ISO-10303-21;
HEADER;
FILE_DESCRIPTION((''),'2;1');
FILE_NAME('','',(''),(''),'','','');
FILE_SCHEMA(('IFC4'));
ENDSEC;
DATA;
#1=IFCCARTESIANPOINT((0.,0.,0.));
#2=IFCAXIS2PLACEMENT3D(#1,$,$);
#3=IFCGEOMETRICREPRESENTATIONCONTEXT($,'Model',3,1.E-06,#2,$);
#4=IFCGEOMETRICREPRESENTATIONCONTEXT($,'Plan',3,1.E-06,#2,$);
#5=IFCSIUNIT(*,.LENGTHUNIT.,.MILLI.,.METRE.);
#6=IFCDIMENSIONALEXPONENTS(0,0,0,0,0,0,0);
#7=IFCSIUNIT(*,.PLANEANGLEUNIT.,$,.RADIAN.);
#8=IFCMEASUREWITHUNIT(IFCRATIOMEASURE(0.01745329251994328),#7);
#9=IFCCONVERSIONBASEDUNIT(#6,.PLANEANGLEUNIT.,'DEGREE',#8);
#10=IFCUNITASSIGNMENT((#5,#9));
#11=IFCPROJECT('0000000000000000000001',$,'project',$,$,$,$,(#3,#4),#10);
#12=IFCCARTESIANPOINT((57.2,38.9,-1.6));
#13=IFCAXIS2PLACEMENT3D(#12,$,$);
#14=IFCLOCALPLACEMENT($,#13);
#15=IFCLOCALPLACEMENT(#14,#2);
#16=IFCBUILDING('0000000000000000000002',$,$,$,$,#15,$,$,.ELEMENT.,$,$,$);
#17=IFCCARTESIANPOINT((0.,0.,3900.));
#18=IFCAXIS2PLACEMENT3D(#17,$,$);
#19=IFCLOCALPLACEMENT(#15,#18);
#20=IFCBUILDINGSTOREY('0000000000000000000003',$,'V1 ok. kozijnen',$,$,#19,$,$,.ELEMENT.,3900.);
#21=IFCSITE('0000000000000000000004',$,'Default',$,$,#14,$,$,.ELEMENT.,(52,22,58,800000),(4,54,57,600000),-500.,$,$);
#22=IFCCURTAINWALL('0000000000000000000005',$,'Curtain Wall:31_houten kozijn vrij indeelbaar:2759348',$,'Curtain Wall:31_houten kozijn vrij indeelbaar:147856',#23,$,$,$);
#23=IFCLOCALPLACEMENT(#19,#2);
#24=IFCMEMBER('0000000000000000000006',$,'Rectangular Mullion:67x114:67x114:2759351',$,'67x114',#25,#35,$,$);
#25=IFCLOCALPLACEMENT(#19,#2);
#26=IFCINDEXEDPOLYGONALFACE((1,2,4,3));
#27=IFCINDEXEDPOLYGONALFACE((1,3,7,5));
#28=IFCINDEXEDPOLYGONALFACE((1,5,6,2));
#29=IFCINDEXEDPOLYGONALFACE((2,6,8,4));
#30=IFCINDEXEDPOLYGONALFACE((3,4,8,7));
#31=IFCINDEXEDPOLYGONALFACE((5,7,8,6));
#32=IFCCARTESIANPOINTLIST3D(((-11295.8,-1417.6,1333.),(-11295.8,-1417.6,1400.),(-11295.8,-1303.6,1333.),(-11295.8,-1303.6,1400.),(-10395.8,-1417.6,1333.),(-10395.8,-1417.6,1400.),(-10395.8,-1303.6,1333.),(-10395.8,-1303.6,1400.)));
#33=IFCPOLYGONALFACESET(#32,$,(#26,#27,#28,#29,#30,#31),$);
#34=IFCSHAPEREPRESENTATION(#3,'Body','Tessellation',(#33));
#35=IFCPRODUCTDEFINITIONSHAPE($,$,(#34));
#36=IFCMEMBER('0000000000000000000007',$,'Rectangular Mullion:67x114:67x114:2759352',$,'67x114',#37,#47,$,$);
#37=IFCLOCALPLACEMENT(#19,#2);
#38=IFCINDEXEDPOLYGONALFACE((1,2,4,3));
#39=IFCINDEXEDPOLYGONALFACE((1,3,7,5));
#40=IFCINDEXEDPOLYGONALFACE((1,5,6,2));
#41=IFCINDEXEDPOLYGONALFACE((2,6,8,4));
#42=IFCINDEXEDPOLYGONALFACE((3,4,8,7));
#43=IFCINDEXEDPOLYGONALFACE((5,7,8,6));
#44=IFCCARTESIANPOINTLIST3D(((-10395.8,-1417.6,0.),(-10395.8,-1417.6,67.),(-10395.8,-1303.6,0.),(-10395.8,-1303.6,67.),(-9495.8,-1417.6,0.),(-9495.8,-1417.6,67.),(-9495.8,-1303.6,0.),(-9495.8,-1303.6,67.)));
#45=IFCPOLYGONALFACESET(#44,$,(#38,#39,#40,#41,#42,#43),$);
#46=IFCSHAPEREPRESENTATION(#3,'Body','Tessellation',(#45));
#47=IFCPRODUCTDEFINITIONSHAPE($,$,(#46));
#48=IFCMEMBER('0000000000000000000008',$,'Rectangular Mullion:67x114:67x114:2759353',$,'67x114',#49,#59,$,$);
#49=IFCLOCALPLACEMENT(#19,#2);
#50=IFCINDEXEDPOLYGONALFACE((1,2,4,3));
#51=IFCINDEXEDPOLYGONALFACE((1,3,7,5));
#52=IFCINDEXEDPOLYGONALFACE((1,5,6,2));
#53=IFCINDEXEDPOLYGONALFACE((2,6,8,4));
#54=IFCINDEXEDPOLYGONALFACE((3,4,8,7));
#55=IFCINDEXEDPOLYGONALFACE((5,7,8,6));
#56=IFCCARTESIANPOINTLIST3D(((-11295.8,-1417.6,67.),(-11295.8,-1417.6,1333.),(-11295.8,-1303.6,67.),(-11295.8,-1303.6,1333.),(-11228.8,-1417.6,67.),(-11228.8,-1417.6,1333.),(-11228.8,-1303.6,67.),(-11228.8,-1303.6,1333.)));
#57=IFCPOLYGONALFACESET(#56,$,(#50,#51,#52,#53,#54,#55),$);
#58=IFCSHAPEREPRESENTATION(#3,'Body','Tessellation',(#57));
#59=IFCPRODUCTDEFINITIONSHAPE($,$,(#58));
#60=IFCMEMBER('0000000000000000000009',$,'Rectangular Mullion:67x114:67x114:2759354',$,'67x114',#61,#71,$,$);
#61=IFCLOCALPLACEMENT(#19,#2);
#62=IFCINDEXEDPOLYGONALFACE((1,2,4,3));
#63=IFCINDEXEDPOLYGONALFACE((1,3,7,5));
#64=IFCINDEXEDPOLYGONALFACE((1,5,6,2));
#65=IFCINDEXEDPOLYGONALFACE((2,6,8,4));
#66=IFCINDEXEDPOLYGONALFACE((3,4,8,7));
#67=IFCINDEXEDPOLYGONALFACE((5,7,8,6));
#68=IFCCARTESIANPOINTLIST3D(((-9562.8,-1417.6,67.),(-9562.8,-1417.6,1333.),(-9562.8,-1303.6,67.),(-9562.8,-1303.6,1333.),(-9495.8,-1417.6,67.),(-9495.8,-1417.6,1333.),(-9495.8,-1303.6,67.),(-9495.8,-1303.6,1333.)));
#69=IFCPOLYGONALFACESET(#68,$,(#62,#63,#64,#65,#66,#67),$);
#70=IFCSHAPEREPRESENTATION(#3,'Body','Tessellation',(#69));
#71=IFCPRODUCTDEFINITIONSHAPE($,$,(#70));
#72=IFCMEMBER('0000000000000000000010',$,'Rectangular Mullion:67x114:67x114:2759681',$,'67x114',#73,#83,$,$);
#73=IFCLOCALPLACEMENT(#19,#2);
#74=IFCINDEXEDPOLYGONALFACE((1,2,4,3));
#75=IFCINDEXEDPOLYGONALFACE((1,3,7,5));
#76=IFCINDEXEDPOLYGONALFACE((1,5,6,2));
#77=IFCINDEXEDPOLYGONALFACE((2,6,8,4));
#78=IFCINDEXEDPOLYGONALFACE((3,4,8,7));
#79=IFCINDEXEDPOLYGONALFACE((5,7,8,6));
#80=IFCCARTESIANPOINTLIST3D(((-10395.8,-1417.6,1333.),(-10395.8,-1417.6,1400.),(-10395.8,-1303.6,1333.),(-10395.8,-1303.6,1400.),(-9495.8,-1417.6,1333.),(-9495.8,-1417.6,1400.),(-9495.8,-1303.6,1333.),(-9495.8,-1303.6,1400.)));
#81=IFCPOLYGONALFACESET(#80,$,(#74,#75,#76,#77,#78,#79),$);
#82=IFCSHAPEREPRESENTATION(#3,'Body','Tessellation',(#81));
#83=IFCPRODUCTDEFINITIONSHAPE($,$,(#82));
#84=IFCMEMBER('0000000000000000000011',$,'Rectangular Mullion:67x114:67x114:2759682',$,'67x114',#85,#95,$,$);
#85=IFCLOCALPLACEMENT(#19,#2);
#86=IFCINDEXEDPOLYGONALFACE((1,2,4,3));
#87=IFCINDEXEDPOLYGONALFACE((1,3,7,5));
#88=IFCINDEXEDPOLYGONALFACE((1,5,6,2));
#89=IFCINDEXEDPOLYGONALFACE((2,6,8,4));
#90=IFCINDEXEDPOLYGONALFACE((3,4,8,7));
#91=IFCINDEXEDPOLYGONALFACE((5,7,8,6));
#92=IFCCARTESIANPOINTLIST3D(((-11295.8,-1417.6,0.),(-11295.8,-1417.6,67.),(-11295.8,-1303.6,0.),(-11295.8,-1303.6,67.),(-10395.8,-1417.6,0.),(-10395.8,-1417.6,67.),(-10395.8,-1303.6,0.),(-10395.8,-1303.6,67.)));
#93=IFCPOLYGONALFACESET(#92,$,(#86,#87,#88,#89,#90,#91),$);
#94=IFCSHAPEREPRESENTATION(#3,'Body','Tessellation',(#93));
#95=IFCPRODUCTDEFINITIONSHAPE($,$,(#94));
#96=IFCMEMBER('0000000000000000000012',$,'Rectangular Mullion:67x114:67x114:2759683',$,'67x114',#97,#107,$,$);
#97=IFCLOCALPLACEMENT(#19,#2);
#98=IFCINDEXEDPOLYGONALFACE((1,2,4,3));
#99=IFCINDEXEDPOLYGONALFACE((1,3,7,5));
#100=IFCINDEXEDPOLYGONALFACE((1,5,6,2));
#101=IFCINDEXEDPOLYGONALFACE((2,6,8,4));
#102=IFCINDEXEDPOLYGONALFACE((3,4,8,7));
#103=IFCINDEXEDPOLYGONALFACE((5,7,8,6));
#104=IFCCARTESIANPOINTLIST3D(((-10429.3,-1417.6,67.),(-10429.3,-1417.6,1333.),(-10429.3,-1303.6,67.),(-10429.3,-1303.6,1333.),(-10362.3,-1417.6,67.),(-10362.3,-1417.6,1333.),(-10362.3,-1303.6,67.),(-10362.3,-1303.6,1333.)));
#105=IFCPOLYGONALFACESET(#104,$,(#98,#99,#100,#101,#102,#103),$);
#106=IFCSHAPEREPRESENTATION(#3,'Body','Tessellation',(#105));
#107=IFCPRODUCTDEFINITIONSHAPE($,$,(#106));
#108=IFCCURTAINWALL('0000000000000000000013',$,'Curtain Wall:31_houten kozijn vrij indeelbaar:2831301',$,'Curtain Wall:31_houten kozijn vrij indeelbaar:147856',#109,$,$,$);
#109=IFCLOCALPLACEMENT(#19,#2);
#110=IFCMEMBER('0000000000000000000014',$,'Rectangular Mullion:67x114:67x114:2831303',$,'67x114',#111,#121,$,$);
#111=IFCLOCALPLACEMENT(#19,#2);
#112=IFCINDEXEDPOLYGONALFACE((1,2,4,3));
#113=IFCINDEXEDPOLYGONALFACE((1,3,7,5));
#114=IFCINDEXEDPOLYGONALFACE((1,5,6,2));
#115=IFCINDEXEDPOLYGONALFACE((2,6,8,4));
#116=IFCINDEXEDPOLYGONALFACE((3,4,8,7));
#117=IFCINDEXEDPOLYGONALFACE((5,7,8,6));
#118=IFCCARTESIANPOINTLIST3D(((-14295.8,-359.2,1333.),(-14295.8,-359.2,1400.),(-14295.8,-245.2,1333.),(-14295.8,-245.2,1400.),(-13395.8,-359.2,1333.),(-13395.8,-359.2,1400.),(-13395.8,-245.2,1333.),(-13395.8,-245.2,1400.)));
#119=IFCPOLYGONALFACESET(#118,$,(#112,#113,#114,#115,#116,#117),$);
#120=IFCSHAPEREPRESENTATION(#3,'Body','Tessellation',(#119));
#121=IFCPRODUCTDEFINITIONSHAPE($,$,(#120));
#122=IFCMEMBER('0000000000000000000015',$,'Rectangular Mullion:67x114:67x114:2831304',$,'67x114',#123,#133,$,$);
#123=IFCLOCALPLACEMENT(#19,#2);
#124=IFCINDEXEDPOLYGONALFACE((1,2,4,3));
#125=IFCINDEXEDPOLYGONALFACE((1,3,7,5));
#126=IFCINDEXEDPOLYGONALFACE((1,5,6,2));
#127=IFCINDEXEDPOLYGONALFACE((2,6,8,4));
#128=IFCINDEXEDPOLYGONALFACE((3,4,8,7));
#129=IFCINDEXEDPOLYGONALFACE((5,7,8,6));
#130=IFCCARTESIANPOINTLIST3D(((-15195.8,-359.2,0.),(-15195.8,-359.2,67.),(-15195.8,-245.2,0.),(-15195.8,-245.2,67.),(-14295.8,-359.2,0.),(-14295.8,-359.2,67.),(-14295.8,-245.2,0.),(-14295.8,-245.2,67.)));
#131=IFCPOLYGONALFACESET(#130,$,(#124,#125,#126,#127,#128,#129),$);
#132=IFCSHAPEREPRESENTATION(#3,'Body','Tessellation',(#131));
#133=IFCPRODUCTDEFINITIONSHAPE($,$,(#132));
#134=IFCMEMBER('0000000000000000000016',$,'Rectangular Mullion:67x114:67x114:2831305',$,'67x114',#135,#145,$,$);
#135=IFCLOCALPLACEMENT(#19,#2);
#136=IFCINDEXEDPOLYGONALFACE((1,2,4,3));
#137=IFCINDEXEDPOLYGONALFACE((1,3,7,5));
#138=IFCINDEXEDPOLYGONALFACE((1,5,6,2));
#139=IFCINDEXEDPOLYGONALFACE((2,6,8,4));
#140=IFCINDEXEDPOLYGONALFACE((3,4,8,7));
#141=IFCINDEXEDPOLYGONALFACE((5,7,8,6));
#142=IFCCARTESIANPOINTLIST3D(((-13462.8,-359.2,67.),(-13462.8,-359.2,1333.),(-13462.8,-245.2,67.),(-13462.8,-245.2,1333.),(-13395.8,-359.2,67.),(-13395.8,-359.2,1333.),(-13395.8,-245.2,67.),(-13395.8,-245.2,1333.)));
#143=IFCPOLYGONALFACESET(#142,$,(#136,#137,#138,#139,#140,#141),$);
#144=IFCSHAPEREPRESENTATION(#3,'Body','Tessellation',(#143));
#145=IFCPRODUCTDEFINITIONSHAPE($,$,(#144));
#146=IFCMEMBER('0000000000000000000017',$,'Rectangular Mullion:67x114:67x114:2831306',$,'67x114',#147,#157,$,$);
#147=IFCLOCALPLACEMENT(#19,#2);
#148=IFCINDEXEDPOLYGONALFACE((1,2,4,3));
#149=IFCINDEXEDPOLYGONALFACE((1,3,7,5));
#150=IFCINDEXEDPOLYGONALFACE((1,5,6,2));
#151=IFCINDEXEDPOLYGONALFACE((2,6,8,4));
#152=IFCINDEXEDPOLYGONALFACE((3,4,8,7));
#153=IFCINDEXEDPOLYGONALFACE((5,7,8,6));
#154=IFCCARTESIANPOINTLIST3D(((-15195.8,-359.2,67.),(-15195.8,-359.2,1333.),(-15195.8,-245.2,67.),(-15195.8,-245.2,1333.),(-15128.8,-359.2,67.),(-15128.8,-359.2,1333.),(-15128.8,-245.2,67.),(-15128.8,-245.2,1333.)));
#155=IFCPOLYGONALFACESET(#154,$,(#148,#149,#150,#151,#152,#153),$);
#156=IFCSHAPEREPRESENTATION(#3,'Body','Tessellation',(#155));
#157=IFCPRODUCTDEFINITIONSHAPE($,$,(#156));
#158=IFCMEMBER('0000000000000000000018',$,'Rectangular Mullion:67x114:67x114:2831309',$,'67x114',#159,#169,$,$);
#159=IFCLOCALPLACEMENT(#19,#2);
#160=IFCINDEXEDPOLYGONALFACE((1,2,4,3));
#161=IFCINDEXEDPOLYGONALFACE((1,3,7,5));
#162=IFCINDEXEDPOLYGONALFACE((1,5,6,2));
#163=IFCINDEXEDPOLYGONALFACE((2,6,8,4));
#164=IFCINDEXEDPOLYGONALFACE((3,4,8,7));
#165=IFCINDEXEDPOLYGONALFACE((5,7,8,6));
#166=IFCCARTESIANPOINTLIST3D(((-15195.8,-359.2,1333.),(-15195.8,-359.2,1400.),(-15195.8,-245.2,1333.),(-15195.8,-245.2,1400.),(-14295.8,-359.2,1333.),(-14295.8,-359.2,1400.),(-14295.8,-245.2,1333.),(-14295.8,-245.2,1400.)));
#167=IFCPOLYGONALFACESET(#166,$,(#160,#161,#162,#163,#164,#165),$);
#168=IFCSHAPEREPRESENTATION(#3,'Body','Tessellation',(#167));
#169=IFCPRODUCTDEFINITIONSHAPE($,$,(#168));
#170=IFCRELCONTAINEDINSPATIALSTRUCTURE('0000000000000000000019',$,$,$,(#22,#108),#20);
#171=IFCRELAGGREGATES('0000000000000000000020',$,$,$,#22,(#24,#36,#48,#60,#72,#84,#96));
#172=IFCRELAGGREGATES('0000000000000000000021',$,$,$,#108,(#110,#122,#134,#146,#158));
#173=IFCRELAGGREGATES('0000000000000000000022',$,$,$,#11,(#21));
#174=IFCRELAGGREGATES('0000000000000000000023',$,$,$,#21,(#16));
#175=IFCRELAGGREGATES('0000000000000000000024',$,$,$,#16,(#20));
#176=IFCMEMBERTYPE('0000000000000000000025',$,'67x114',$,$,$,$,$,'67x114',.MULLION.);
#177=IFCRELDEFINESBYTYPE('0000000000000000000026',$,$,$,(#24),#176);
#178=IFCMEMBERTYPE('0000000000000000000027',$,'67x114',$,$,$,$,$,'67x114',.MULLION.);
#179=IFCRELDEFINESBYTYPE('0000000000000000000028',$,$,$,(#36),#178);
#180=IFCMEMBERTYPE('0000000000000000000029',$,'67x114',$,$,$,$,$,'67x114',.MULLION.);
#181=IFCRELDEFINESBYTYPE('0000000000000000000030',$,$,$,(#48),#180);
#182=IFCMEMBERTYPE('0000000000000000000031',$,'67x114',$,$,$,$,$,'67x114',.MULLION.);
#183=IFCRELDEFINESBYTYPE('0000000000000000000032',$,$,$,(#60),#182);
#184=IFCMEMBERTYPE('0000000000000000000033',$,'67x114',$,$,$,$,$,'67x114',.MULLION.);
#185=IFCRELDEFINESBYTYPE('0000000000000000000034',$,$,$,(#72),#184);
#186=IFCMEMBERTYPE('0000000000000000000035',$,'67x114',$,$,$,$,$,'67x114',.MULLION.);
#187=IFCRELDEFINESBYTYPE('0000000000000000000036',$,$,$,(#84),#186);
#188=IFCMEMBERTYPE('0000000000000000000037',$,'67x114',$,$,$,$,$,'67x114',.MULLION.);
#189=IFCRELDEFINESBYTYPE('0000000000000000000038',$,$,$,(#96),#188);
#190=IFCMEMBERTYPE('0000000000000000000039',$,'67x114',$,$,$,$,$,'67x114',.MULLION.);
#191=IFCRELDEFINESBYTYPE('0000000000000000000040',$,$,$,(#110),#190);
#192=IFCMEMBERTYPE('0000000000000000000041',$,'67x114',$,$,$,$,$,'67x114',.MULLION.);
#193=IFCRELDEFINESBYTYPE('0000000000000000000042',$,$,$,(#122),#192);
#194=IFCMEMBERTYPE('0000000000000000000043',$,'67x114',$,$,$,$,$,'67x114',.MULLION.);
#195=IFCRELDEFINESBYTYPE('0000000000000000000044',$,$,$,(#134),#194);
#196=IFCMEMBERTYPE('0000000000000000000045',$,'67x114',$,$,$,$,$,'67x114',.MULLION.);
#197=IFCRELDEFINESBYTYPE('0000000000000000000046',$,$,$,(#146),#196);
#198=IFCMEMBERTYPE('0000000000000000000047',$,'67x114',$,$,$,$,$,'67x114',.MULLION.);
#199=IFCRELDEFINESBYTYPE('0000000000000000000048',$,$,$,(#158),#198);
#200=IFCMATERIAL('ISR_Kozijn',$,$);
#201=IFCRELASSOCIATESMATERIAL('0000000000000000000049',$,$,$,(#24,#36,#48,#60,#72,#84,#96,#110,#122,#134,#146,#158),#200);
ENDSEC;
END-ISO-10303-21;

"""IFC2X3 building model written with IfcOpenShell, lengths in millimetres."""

from ifc_helpers import new_model, entity, si_unit, converted_unit, frame, origin, origin_2d_with_axis, place, context, project, spatial, rectangle, extrude, source, transform, mapped, material, type_object, type_shapes, element, aggregate, save


model = new_model("IFC2X3")

# Units and contexts
model_context = context("Model", 3, precision=1e-06, world=origin())
plan_context = context("Plan", 3, precision=1e-06, world=origin())
ifc_project = project(units=[si_unit("LENGTHUNIT", "METRE", prefix="MILLI"), converted_unit("PLANEANGLEUNIT", "DEGREE", entity("IfcRatioMeasure", 0.01745329251994328), si_unit("PLANEANGLEUNIT", "RADIAN"), dimensions=[0, 0, 0, 0, 0, 0, 0])], contexts=[model_context, plan_context])

# Site, building, storey
site_placement = place(None, frame((57.2, 38.9, -1.6)))
site = spatial("IfcSite", under=ifc_project, at=site_placement, Name="Default", CompositionType="ELEMENT", RefLatitude=(52, 22, 58, 800000), RefLongitude=(4, 54, 57, 600000), RefElevation=-500.0)
building_placement = place(site_placement, origin())
building = spatial("IfcBuilding", under=site, at=building_placement, CompositionType="ELEMENT")
storey_placement = place(building_placement, frame((0.0, 0.0, 3900.0)))
storey = spatial("IfcBuildingStorey", under=building, at=storey_placement, Name="V1 ok. kozijnen", CompositionType="ELEMENT", Elevation=3900.0)

# Curtain walls, members
curtain_wall_1_placement = place(storey_placement, origin())
curtain_wall_1 = element("IfcCurtainWall", 1, at=curtain_wall_1_placement, inside=storey, Name="Curtain Wall:31_houten kozijn vrij indeelbaar:2759348", ObjectType="Curtain Wall:31_houten kozijn vrij indeelbaar:147856")
ifc_material_1 = material(Name="ISR_Kozijn")
member_type_1 = type_object("IfcMemberType", Name="67x114", ElementType="67x114", PredefinedType="MULLION")
shared_shape_1 = source(origin(), model_context, "Body", "SweptSolid", [
    extrude(rectangle(XDim=67.0, YDim=114.0, at=origin_2d_with_axis()), frame((-33.5, 57.0, -900.0), z_axis=(0.0, 0.0, 1.0), x_axis=(-1.0, 0.0, 0.0)), (0.0, 0.0, 1.0), 900.0),
])
type_shapes(member_type_1, [shared_shape_1])
member_1_placement = place(storey_placement, frame((-11295.8, -1417.6, 1400.0), z_axis=(-1.0, 0.0, 0.0), x_axis=(0.0, 0.0, 1.0)))
member_1 = element("IfcMember", 2, at=member_1_placement, type_object=member_type_1, material=ifc_material_1, Name="Rectangular Mullion:67x114:67x114:2759351", ObjectType="67x114", context=model_context, shape_type="MappedRepresentation", body=[
    mapped(shared_shape_1, transform((0.0, 0.0, 0.0), scale=1.0)),
])
member_type_2 = type_object("IfcMemberType", Name="67x114", ElementType="67x114", PredefinedType="MULLION")
shared_shape_2 = source(origin(), model_context, "Body", "SweptSolid", [
    extrude(rectangle(XDim=67.0, YDim=114.0, at=origin_2d_with_axis()), frame((-33.5, 57.0, -900.0), z_axis=(0.0, 0.0, 1.0), x_axis=(-1.0, 0.0, 0.0)), (0.0, 0.0, 1.0), 900.0),
])
type_shapes(member_type_2, [shared_shape_2])
member_2_placement = place(storey_placement, frame((-9495.8, -1417.6, 0.0), z_axis=(1.0, 0.0, 0.0), x_axis=(0.0, 0.0, -1.0)))
member_2 = element("IfcMember", 3, at=member_2_placement, type_object=member_type_2, material=ifc_material_1, Name="Rectangular Mullion:67x114:67x114:2759352", ObjectType="67x114", context=model_context, shape_type="MappedRepresentation", body=[
    mapped(shared_shape_2, transform((0.0, 0.0, 0.0), scale=1.0)),
])
member_type_3 = type_object("IfcMemberType", Name="67x114", ElementType="67x114", PredefinedType="MULLION")
shared_shape_3 = source(origin(), model_context, "Body", "SweptSolid", [
    extrude(rectangle(XDim=67.0, YDim=114.0, at=origin_2d_with_axis()), frame((-33.5, 57.0, -1266.0), z_axis=(0.0, 0.0, 1.0), x_axis=(-1.0, 0.0, 0.0)), (0.0, 0.0, 1.0), 1266.0),
])
type_shapes(member_type_3, [shared_shape_3])
member_3_placement = place(storey_placement, frame((-11295.8, -1417.6, 67.0), z_axis=(0.0, 0.0, -1.0), x_axis=(-1.0, 0.0, 0.0)))
member_3 = element("IfcMember", 4, at=member_3_placement, type_object=member_type_3, material=ifc_material_1, Name="Rectangular Mullion:67x114:67x114:2759353", ObjectType="67x114", context=model_context, shape_type="MappedRepresentation", body=[
    mapped(shared_shape_3, transform((0.0, 0.0, 0.0), scale=1.0)),
])
member_type_4 = type_object("IfcMemberType", Name="67x114", ElementType="67x114", PredefinedType="MULLION")
shared_shape_4 = source(origin(), model_context, "Body", "SweptSolid", [
    extrude(rectangle(XDim=67.0, YDim=114.0, at=origin_2d_with_axis()), frame((-33.5, 57.0, -1266.0), z_axis=(0.0, 0.0, 1.0), x_axis=(-1.0, 0.0, 0.0)), (0.0, 0.0, 1.0), 1266.0),
])
type_shapes(member_type_4, [shared_shape_4])
member_4_placement = place(storey_placement, frame((-9495.8, -1417.6, 1333.0)))
member_4 = element("IfcMember", 5, at=member_4_placement, type_object=member_type_4, material=ifc_material_1, Name="Rectangular Mullion:67x114:67x114:2759354", ObjectType="67x114", context=model_context, shape_type="MappedRepresentation", body=[
    mapped(shared_shape_4, transform((0.0, 0.0, 0.0), scale=1.0)),
])
member_type_5 = type_object("IfcMemberType", Name="67x114", ElementType="67x114", PredefinedType="MULLION")
shared_shape_5 = source(origin(), model_context, "Body", "SweptSolid", [
    extrude(rectangle(XDim=67.0, YDim=114.0, at=origin_2d_with_axis()), frame((-33.5, 57.0, -900.0), z_axis=(0.0, 0.0, 1.0), x_axis=(-1.0, 0.0, 0.0)), (0.0, 0.0, 1.0), 900.0),
])
type_shapes(member_type_5, [shared_shape_5])
member_5_placement = place(storey_placement, frame((-10395.8, -1417.6, 1400.0), z_axis=(-1.0, 0.0, 0.0), x_axis=(0.0, 0.0, 1.0)))
member_5 = element("IfcMember", 6, at=member_5_placement, type_object=member_type_5, material=ifc_material_1, Name="Rectangular Mullion:67x114:67x114:2759681", ObjectType="67x114", context=model_context, shape_type="MappedRepresentation", body=[
    mapped(shared_shape_5, transform((0.0, 0.0, 0.0), scale=1.0)),
])
member_type_6 = type_object("IfcMemberType", Name="67x114", ElementType="67x114", PredefinedType="MULLION")
shared_shape_6 = source(origin(), model_context, "Body", "SweptSolid", [
    extrude(rectangle(XDim=67.0, YDim=114.0, at=origin_2d_with_axis()), frame((-33.5, 57.0, -900.0), z_axis=(0.0, 0.0, 1.0), x_axis=(-1.0, 0.0, 0.0)), (0.0, 0.0, 1.0), 900.0),
])
type_shapes(member_type_6, [shared_shape_6])
member_6_placement = place(storey_placement, frame((-10395.8, -1417.6, 0.0), z_axis=(1.0, 0.0, 0.0), x_axis=(0.0, 0.0, -1.0)))
member_6 = element("IfcMember", 7, at=member_6_placement, type_object=member_type_6, material=ifc_material_1, Name="Rectangular Mullion:67x114:67x114:2759682", ObjectType="67x114", context=model_context, shape_type="MappedRepresentation", body=[
    mapped(shared_shape_6, transform((0.0, 0.0, 0.0), scale=1.0)),
])
member_type_7 = type_object("IfcMemberType", Name="67x114", ElementType="67x114", PredefinedType="MULLION")
shared_shape_7 = source(origin(), model_context, "Body", "SweptSolid", [
    extrude(rectangle(XDim=67.0, YDim=114.0, at=origin_2d_with_axis()), frame((0.0, 57.0, -1266.0), z_axis=(0.0, 0.0, 1.0), x_axis=(-1.0, 0.0, 0.0)), (0.0, 0.0, 1.0), 1266.0),
])
type_shapes(member_type_7, [shared_shape_7])
member_7_placement = place(storey_placement, frame((-10395.8, -1417.6, 67.0), z_axis=(0.0, 0.0, -1.0), x_axis=(-1.0, 0.0, 0.0)))
member_7 = element("IfcMember", 8, at=member_7_placement, type_object=member_type_7, material=ifc_material_1, Name="Rectangular Mullion:67x114:67x114:2759683", ObjectType="67x114", context=model_context, shape_type="MappedRepresentation", body=[
    mapped(shared_shape_7, transform((0.0, 0.0, 0.0), scale=1.0)),
])
curtain_wall_2_placement = place(storey_placement, origin())
curtain_wall_2 = element("IfcCurtainWall", 9, at=curtain_wall_2_placement, inside=storey, Name="Curtain Wall:31_houten kozijn vrij indeelbaar:2831301", ObjectType="Curtain Wall:31_houten kozijn vrij indeelbaar:147856")
member_type_8 = type_object("IfcMemberType", Name="67x114", ElementType="67x114", PredefinedType="MULLION")
shared_shape_8 = source(origin(), model_context, "Body", "SweptSolid", [
    extrude(rectangle(XDim=67.0, YDim=114.0, at=origin_2d_with_axis()), frame((-33.5, -57.0, -900.0), z_axis=(0.0, 0.0, 1.0), x_axis=(-1.0, 0.0, 0.0)), (0.0, 0.0, 1.0), 900.0),
])
type_shapes(member_type_8, [shared_shape_8])
member_8_placement = place(storey_placement, frame((-13395.8, -359.2, 1400.0), z_axis=(1.0, 0.0, 0.0), x_axis=(0.0, 0.0, 1.0)))
member_8 = element("IfcMember", 10, at=member_8_placement, type_object=member_type_8, material=ifc_material_1, Name="Rectangular Mullion:67x114:67x114:2831303", ObjectType="67x114", context=model_context, shape_type="MappedRepresentation", body=[
    mapped(shared_shape_8, transform((0.0, 0.0, 0.0), scale=1.0)),
])
member_type_9 = type_object("IfcMemberType", Name="67x114", ElementType="67x114", PredefinedType="MULLION")
shared_shape_9 = source(origin(), model_context, "Body", "SweptSolid", [
    extrude(rectangle(XDim=67.0, YDim=114.0, at=origin_2d_with_axis()), frame((-33.5, -57.0, -900.0), z_axis=(0.0, 0.0, 1.0), x_axis=(-1.0, 0.0, 0.0)), (0.0, 0.0, 1.0), 900.0),
])
type_shapes(member_type_9, [shared_shape_9])
member_9_placement = place(storey_placement, frame((-15195.8, -359.2, 0.0), z_axis=(-1.0, 0.0, 0.0), x_axis=(0.0, 0.0, -1.0)))
member_9 = element("IfcMember", 11, at=member_9_placement, type_object=member_type_9, material=ifc_material_1, Name="Rectangular Mullion:67x114:67x114:2831304", ObjectType="67x114", context=model_context, shape_type="MappedRepresentation", body=[
    mapped(shared_shape_9, transform((0.0, 0.0, 0.0), scale=1.0)),
])
member_type_10 = type_object("IfcMemberType", Name="67x114", ElementType="67x114", PredefinedType="MULLION")
shared_shape_10 = source(origin(), model_context, "Body", "SweptSolid", [
    extrude(rectangle(XDim=67.0, YDim=114.0, at=origin_2d_with_axis()), frame((-33.5, -57.0, -1266.0), z_axis=(0.0, 0.0, 1.0), x_axis=(-1.0, 0.0, 0.0)), (0.0, 0.0, 1.0), 1266.0),
])
type_shapes(member_type_10, [shared_shape_10])
member_10_placement = place(storey_placement, frame((-13395.8, -359.2, 67.0), z_axis=(0.0, 0.0, -1.0), x_axis=(1.0, 0.0, 0.0)))
member_10 = element("IfcMember", 12, at=member_10_placement, type_object=member_type_10, material=ifc_material_1, Name="Rectangular Mullion:67x114:67x114:2831305", ObjectType="67x114", context=model_context, shape_type="MappedRepresentation", body=[
    mapped(shared_shape_10, transform((0.0, 0.0, 0.0), scale=1.0)),
])
member_type_11 = type_object("IfcMemberType", Name="67x114", ElementType="67x114", PredefinedType="MULLION")
shared_shape_11 = source(origin(), model_context, "Body", "SweptSolid", [
    extrude(rectangle(XDim=67.0, YDim=114.0, at=origin_2d_with_axis()), frame((-33.5, -57.0, -1266.0), z_axis=(0.0, 0.0, 1.0), x_axis=(-1.0, 0.0, 0.0)), (0.0, 0.0, 1.0), 1266.0),
])
type_shapes(member_type_11, [shared_shape_11])
member_11_placement = place(storey_placement, frame((-15195.8, -359.2, 1333.0), z_axis=(0.0, 0.0, 1.0), x_axis=(-1.0, 0.0, 0.0)))
member_11 = element("IfcMember", 13, at=member_11_placement, type_object=member_type_11, material=ifc_material_1, Name="Rectangular Mullion:67x114:67x114:2831306", ObjectType="67x114", context=model_context, shape_type="MappedRepresentation", body=[
    mapped(shared_shape_11, transform((0.0, 0.0, 0.0), scale=1.0)),
])
member_type_12 = type_object("IfcMemberType", Name="67x114", ElementType="67x114", PredefinedType="MULLION")
shared_shape_12 = source(origin(), model_context, "Body", "SweptSolid", [
    extrude(rectangle(XDim=67.0, YDim=114.0, at=origin_2d_with_axis()), frame((-33.5, -57.0, -900.0), z_axis=(0.0, 0.0, 1.0), x_axis=(-1.0, 0.0, 0.0)), (0.0, 0.0, 1.0), 900.0),
])
type_shapes(member_type_12, [shared_shape_12])
member_12_placement = place(storey_placement, frame((-14295.8, -359.2, 1400.0), z_axis=(1.0, 0.0, 0.0), x_axis=(0.0, 0.0, 1.0)))
member_12 = element("IfcMember", 14, at=member_12_placement, type_object=member_type_12, material=ifc_material_1, Name="Rectangular Mullion:67x114:67x114:2831309", ObjectType="67x114", context=model_context, shape_type="MappedRepresentation", body=[
    mapped(shared_shape_12, transform((0.0, 0.0, 0.0), scale=1.0)),
])

aggregate(curtain_wall_1, [member_1, member_2, member_3, member_4, member_5, member_6, member_7])
aggregate(curtain_wall_2, [member_8, member_9, member_10, member_11, member_12])

save(model, "model.ifc")
